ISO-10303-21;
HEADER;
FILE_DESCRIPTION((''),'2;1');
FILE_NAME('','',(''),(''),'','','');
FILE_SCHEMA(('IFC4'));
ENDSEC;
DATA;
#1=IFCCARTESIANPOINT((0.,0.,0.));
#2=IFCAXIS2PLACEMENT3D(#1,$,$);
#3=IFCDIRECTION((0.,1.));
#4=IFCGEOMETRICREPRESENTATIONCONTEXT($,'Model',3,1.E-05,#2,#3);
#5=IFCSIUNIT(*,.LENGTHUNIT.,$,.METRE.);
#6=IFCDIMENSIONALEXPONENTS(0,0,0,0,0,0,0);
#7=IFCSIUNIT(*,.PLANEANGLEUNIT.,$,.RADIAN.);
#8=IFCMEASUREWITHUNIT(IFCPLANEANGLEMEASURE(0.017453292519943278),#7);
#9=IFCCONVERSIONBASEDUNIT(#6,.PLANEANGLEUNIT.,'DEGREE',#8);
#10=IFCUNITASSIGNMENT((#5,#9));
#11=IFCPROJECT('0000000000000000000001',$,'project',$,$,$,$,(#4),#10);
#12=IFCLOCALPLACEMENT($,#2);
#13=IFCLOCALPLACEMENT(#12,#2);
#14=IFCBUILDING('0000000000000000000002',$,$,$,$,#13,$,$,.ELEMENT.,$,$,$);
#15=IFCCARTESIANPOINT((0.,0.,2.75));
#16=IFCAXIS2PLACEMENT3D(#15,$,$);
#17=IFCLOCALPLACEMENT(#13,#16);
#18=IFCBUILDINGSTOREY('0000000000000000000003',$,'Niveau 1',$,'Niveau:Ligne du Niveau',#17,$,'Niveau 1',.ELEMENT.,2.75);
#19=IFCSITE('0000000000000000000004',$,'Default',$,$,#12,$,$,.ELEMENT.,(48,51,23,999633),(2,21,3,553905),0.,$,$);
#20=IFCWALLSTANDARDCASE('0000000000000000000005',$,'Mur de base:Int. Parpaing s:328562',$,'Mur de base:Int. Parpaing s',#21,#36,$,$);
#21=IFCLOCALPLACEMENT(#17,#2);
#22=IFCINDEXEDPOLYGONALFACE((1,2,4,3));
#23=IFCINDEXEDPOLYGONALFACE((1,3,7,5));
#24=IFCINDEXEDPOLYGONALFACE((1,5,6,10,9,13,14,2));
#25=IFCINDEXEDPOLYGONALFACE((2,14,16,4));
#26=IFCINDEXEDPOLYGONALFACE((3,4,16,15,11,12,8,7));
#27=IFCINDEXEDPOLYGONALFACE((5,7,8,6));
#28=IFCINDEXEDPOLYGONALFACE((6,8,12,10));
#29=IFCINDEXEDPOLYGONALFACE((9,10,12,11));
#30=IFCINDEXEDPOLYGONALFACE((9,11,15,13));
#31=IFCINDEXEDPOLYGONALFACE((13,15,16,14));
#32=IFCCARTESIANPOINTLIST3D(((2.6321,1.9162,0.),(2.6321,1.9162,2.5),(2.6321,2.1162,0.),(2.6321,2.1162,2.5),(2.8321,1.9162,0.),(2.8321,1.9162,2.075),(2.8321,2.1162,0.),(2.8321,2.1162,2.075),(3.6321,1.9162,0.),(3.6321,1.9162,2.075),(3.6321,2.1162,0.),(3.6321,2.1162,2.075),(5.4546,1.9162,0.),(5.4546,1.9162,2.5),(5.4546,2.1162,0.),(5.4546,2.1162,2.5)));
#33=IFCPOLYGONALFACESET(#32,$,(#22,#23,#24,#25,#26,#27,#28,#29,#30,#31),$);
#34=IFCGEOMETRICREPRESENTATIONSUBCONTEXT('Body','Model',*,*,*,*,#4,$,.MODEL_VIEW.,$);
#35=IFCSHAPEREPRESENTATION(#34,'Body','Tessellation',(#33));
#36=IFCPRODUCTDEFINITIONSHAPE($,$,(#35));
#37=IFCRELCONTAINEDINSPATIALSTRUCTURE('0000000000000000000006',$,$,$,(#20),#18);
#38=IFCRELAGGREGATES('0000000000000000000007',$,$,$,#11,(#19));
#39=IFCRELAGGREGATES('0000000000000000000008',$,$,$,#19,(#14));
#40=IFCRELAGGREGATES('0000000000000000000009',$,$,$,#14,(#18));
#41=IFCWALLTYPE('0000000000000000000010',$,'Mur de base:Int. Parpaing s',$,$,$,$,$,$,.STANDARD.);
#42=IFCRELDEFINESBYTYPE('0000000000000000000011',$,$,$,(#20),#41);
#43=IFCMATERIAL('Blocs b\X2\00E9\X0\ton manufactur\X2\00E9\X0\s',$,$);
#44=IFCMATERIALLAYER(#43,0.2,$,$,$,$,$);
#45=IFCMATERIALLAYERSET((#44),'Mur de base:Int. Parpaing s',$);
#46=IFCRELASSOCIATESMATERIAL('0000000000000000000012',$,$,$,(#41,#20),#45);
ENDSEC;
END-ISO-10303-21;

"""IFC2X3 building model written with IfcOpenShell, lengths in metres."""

from ifc_helpers import new_model, entity, si_unit, converted_unit, direction, frame, frame_2d, origin, place, context, subcontext, project, spatial, rectangle, extrude, material, layer, layer_set, layer_usage, type_object, element, save


model = new_model("IFC2X3")

# Units and contexts
model_context = context("Model", 3, precision=1e-05, world=origin(), true_north=direction((0.0, 1.0)))
body_context = subcontext(model_context, "Body", "Model", "MODEL_VIEW")
ifc_project = project(units=[si_unit("LENGTHUNIT", "METRE"), converted_unit("PLANEANGLEUNIT", "DEGREE", entity("IfcPlaneAngleMeasure", 0.017453292519943278), si_unit("PLANEANGLEUNIT", "RADIAN"), dimensions=[0, 0, 0, 0, 0, 0, 0])], contexts=[model_context])

# Site, building, storey
site_placement = place(None, origin())
site = spatial("IfcSite", under=ifc_project, at=site_placement, Name="Default", CompositionType="ELEMENT", RefLatitude=(48, 51, 23, 999633), RefLongitude=(2, 21, 3, 553905), RefElevation=0.0)
building_placement = place(site_placement, origin())
building = spatial("IfcBuilding", under=site, at=building_placement, CompositionType="ELEMENT")
storey_placement = place(building_placement, frame((0.0, 0.0, 2.75)))
storey = spatial("IfcBuildingStorey", under=building, at=storey_placement, Name="Niveau 1", ObjectType="Niveau:Ligne du Niveau", LongName="Niveau 1", CompositionType="ELEMENT", Elevation=2.75)

# Wall, opening
ifc_material_1 = material(Name="Blocs béton manufacturés")
ifc_layer_1 = layer(ifc_material_1, 0.2)
ifc_layer_set_1 = layer_set([ifc_layer_1], Name="Mur de base:Int. Parpaing s")
wall_type_1 = type_object("IfcWallType", Name="Mur de base:Int. Parpaing s", PredefinedType="STANDARD", material=ifc_layer_set_1)
ifc_layer_usage_1 = layer_usage(ifc_layer_set_1, "AXIS2", "NEGATIVE", 0.1)
wall_1_placement = place(storey_placement, frame((2.6321, 2.0162, 0.0)))
wall_1 = element("IfcWallStandardCase", 1, at=wall_1_placement, inside=storey, type_object=wall_type_1, material=ifc_layer_usage_1, Name="Mur de base:Int. Parpaing s:328562", ObjectType="Mur de base:Int. Parpaing s", context=body_context, shape_type="SweptSolid", body=[
    extrude(rectangle(XDim=2.8225, YDim=0.2, at=frame_2d((1.4113, 0.0), x_axis=(1.0, 0.0))), origin(), (0.0, 0.0, 1.0), 2.5),
])
opening_1_placement = place(wall_1_placement, frame((0.2, -0.1, 0.0)))
element("IfcOpeningElement", 2, at=opening_1_placement, cuts=wall_1, ObjectType="Opening", context=body_context, shape_type="SweptSolid", body=[
    extrude(rectangle(XDim=2.075, YDim=0.8, at=frame_2d((1.0375, 0.4), x_axis=(1.0, 0.0))), frame((0.0, 0.0, 0.0), z_axis=(0.0, 1.0, 0.0), x_axis=(0.0, 0.0, 1.0)), (0.0, 0.0, 1.0), 0.2),
])

save(model, "model.ifc")
